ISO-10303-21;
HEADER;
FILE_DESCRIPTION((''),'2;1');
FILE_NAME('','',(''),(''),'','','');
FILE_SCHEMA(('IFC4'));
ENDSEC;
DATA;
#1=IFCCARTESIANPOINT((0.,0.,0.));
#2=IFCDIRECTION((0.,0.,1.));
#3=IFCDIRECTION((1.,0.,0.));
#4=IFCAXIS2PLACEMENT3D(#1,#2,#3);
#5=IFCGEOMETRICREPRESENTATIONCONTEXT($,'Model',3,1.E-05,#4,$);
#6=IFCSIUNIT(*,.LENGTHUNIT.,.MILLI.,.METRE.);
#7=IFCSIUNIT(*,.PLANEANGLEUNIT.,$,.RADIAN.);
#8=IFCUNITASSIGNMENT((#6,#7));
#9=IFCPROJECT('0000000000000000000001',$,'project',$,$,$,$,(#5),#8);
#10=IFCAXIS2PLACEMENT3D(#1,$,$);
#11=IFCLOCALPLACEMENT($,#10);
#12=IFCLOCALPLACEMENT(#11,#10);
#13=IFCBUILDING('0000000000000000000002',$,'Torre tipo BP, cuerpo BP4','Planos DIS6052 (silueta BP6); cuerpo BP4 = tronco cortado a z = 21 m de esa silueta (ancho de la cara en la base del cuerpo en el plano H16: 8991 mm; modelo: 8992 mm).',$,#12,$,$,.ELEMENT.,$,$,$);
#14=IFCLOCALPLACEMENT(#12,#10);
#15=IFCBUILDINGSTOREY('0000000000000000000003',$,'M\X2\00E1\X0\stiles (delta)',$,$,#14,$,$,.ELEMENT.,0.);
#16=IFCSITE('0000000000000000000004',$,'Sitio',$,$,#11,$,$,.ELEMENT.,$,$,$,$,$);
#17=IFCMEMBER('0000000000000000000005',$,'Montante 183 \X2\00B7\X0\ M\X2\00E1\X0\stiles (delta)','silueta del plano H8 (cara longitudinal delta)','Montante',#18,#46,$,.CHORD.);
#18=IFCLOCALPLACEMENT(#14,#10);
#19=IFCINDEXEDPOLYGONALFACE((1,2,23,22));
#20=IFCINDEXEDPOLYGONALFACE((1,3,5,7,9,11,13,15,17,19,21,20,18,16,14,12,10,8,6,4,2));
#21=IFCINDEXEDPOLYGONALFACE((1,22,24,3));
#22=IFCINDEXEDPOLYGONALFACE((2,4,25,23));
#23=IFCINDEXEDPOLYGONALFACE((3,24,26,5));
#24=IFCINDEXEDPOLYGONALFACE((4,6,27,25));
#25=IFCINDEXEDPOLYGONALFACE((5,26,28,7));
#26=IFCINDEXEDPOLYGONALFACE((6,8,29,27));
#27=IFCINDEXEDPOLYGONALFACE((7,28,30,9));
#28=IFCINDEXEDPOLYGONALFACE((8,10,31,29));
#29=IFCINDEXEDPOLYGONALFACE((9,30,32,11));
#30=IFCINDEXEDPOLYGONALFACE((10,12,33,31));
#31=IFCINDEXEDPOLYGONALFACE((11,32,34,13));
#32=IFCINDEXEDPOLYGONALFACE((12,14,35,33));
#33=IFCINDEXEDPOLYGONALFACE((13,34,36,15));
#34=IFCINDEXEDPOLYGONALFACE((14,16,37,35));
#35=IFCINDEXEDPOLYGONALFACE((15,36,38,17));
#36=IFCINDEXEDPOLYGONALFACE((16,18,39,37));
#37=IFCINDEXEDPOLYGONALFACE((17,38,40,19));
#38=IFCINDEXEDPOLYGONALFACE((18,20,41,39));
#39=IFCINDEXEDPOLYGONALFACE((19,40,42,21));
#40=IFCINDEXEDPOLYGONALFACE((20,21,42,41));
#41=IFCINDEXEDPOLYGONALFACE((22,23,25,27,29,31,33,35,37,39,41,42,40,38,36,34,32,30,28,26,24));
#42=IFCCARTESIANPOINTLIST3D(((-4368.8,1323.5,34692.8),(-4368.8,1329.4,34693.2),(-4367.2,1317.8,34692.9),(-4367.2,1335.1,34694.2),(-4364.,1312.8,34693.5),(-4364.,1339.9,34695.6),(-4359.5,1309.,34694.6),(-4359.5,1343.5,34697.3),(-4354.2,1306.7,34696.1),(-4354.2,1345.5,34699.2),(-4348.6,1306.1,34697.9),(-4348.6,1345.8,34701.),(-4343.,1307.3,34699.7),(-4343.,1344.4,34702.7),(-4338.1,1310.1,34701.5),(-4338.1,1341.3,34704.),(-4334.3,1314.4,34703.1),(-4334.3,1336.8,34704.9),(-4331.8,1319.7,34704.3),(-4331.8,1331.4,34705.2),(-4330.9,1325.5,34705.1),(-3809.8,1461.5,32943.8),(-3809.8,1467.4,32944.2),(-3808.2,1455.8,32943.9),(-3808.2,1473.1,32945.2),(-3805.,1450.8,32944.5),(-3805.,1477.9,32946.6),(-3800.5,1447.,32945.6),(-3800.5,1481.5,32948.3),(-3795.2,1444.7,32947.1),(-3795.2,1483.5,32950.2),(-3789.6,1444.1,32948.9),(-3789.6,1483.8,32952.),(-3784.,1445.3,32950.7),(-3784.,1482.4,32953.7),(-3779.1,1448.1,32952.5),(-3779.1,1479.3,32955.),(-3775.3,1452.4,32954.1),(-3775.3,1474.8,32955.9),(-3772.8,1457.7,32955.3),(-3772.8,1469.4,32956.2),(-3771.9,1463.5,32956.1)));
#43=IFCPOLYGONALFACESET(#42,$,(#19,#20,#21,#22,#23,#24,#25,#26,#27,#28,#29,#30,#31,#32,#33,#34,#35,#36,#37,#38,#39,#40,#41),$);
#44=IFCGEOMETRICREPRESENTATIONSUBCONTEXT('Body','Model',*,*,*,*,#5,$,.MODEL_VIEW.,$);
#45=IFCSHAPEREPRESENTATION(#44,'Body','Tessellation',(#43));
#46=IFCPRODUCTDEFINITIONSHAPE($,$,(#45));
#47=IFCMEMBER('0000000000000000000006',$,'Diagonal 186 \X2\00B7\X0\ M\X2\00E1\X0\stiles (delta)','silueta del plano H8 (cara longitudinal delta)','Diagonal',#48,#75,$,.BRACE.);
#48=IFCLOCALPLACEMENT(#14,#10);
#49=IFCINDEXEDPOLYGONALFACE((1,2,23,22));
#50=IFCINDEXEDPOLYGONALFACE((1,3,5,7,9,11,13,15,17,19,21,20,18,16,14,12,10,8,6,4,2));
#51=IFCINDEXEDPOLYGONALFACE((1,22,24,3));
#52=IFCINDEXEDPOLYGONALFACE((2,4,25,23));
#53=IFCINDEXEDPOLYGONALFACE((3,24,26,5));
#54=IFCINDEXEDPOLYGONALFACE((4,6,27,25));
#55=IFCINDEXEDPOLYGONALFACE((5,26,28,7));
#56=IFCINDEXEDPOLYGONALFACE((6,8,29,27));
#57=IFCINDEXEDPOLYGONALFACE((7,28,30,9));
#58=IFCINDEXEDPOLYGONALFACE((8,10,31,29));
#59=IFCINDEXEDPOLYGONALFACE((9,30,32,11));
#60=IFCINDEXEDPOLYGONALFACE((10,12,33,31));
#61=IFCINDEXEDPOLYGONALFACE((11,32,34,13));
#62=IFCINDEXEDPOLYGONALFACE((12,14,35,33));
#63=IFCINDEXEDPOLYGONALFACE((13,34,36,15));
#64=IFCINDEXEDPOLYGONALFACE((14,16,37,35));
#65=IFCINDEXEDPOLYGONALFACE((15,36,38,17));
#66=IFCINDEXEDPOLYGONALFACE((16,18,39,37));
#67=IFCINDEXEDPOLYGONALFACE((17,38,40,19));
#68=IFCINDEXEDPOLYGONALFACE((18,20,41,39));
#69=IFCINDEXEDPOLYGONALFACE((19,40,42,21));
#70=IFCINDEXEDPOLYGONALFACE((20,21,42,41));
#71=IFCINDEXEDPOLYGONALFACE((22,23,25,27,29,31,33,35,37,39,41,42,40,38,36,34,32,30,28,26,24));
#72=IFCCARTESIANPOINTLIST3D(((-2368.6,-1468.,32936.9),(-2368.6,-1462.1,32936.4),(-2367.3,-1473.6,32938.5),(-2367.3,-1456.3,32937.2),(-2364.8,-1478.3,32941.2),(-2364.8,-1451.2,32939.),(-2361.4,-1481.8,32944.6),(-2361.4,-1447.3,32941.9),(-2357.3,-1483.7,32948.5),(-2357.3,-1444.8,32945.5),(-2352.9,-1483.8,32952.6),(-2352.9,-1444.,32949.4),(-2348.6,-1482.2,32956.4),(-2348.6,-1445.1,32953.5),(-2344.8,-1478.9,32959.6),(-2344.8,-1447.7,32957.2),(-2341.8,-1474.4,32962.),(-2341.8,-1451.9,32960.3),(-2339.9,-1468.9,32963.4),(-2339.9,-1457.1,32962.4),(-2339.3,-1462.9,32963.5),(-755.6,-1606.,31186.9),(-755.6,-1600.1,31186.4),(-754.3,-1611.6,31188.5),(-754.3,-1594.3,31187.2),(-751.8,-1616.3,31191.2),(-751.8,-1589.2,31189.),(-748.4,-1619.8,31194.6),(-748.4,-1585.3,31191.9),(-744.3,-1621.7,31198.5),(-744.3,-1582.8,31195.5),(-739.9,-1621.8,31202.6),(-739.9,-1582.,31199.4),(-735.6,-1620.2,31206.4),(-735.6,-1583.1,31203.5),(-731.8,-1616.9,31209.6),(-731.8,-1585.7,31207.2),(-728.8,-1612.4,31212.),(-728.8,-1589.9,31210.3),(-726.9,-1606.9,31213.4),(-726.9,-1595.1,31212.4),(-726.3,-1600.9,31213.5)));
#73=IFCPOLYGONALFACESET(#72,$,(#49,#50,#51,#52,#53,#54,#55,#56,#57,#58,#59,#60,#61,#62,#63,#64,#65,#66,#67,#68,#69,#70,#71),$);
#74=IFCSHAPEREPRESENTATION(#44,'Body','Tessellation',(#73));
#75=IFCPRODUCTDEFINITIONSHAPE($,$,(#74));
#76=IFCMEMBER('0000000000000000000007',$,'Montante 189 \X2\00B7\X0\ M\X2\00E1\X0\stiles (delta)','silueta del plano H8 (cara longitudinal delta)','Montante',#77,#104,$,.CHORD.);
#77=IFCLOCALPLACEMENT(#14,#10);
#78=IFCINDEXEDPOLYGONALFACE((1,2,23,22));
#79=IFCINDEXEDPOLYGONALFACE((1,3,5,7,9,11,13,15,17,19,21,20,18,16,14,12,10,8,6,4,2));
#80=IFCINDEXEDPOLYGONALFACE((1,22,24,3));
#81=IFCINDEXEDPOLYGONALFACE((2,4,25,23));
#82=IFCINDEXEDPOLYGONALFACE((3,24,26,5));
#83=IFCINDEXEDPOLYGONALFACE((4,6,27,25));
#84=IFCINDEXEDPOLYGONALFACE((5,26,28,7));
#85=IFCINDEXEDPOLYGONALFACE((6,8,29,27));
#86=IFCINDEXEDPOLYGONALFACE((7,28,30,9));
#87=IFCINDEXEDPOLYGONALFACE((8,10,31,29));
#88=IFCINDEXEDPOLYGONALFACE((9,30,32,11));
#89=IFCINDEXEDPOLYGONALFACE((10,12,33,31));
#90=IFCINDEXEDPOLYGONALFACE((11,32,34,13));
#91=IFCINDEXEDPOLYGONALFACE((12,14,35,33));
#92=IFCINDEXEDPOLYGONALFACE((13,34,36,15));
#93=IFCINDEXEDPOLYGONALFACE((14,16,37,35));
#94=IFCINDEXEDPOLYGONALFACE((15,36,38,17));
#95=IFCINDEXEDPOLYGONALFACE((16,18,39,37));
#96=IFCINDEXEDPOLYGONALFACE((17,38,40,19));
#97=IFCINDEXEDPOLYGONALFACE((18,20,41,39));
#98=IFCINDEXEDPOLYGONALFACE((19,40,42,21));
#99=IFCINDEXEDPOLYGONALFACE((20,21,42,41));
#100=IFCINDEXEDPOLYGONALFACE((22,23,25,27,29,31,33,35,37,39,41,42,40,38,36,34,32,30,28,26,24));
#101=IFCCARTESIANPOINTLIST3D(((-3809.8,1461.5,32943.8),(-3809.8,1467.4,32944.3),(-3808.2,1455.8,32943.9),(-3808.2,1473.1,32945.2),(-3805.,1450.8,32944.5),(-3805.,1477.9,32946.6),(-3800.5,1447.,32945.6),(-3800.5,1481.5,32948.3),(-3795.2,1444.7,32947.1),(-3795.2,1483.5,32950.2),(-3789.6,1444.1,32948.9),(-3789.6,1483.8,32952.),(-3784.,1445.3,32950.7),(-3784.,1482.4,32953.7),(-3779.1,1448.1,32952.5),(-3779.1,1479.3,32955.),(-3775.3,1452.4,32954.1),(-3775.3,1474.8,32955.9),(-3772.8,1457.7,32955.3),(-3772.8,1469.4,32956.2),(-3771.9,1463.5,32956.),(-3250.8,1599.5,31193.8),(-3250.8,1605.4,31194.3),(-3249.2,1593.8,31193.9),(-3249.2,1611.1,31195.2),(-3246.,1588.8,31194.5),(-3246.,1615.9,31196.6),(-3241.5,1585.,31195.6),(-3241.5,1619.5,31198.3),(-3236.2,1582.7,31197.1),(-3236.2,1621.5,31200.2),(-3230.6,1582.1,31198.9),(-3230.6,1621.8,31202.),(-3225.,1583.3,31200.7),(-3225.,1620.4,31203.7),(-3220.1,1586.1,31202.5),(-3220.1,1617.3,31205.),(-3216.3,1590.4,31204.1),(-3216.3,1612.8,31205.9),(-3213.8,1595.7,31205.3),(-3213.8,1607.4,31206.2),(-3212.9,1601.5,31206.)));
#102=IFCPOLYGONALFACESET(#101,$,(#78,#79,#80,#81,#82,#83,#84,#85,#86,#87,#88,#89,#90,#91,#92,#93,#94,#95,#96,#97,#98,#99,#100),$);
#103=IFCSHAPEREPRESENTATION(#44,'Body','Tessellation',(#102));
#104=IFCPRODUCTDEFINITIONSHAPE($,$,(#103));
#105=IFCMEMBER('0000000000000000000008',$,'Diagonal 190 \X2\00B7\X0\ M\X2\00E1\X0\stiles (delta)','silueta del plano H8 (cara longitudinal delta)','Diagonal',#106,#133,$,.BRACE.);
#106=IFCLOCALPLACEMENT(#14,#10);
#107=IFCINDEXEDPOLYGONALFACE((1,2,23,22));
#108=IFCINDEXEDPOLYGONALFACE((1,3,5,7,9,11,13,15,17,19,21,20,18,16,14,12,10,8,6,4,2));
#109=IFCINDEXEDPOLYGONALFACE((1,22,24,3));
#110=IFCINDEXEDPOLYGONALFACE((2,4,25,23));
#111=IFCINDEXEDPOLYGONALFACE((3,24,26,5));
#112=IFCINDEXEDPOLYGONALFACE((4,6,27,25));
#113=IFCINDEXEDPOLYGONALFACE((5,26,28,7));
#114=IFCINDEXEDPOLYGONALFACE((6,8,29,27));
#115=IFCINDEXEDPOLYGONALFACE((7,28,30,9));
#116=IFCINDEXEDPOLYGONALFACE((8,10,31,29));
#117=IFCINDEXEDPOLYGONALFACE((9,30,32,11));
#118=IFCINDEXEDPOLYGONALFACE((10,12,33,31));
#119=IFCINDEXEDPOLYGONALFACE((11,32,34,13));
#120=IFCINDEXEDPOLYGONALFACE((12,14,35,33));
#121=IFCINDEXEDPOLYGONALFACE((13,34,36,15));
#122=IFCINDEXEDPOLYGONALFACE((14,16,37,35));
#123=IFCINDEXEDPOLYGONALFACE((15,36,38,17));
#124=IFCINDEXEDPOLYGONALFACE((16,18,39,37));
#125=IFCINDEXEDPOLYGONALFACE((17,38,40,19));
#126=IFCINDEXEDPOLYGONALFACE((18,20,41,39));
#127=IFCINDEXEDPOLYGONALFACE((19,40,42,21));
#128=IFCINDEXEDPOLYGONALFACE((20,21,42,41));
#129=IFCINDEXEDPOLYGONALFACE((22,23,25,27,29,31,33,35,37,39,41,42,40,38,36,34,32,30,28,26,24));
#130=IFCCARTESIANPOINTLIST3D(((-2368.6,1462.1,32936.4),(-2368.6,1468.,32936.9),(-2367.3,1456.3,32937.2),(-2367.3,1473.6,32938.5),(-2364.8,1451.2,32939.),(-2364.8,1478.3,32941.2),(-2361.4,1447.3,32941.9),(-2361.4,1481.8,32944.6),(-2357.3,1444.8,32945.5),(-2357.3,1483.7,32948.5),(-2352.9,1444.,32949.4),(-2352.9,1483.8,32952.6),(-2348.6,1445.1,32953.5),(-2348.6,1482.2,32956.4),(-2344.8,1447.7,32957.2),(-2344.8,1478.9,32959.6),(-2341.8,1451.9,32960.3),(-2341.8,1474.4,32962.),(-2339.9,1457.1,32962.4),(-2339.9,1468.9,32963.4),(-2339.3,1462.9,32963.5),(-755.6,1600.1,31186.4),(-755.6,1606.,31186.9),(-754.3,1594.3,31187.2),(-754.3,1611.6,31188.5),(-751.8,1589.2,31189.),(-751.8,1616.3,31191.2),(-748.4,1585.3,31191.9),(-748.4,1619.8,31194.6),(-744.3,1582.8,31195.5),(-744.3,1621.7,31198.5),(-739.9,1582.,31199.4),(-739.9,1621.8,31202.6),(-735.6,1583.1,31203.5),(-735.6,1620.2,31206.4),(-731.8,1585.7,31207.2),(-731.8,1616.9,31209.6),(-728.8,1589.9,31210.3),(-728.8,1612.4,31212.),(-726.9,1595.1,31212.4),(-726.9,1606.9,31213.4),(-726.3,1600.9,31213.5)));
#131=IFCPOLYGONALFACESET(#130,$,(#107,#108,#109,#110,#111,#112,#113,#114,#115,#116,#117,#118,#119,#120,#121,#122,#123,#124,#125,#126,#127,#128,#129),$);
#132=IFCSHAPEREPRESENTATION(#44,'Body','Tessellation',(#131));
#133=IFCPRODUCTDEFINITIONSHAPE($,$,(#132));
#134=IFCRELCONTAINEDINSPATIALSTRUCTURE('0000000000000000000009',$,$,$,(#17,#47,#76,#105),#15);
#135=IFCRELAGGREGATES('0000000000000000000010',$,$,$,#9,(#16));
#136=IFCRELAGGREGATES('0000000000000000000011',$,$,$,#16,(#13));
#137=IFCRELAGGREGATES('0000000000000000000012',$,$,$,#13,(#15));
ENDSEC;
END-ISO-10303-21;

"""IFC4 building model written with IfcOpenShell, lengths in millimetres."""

from ifc_helpers import new_model, si_unit, frame, origin, origin_with_axes, place, context, subcontext, project, spatial, circle, extrude, element, save


model = new_model("IFC4")

# Units and contexts
model_context = context("Model", 3, precision=1e-05, world=origin_with_axes())
body_context = subcontext(model_context, "Body", "Model", "MODEL_VIEW")
ifc_project = project(units=[si_unit("LENGTHUNIT", "METRE", prefix="MILLI"), si_unit("PLANEANGLEUNIT", "RADIAN")], contexts=[model_context])

# Site, building, storey
site_placement = place(None, origin())
site = spatial("IfcSite", under=ifc_project, at=site_placement, Name="Sitio", CompositionType="ELEMENT")
building_placement = place(site_placement, origin())
building = spatial("IfcBuilding", under=site, at=building_placement, Name="Torre tipo BP, cuerpo BP4", Description="Planos DIS6052 (silueta BP6); cuerpo BP4 = tronco cortado a z = 21 m de esa silueta (ancho de la cara en la base del cuerpo en el plano H16: 8991 mm; modelo: 8992 mm).", CompositionType="ELEMENT")
storey_placement = place(building_placement, origin())
storey = spatial("IfcBuildingStorey", under=building, at=storey_placement, Name="Mástiles (delta)", CompositionType="ELEMENT", Elevation=0.0)

# Members
for number, where, z_axis, x_axis, name in (
    (1, (-4350.0, 1326.0, 34699.0), (0.303584, 0.074945, -0.949853), (0.952805, -0.023879, 0.302643), "Montante 183 · Mástiles (delta)"),
):
    element("IfcMember", number, at=place(storey_placement, frame(where, z_axis=z_axis, x_axis=x_axis)), inside=storey, Name=name, Description="silueta del plano H8 (cara longitudinal delta)", ObjectType="Montante", PredefinedType="CHORD", context=body_context, shape_type="SweptSolid", body=[
        extrude(circle(Radius=20.0), None, (0.0, 0.0, 1.0), 1841.3),
    ])
member_1_placement = place(storey_placement, frame((-2354.0, -1464.0, 32950.0), z_axis=(0.676602, -0.057887, -0.73407), x_axis=(0.736348, 0.05319, 0.674509)))
element("IfcMember", 2, at=member_1_placement, inside=storey, Name="Diagonal 186 · Mástiles (delta)", Description="silueta del plano H8 (cara longitudinal delta)", ObjectType="Diagonal", PredefinedType="BRACE", context=body_context, shape_type="SweptSolid", body=[
    extrude(circle(Radius=20.0), None, (0.0, 0.0, 1.0), 2384.0),
])
member_2_placement = place(storey_placement, frame((-3791.0, 1464.0, 32950.0), z_axis=(0.303427, 0.074907, -0.949906), x_axis=(0.952855, -0.023853, 0.302488)))
element("IfcMember", 3, at=member_2_placement, inside=storey, Name="Montante 189 · Mástiles (delta)", Description="silueta del plano H8 (cara longitudinal delta)", ObjectType="Montante", PredefinedType="CHORD", context=body_context, shape_type="SweptSolid", body=[
    extrude(circle(Radius=20.0), None, (0.0, 0.0, 1.0), 1842.3),
])
member_3_placement = place(storey_placement, frame((-2354.0, 1464.0, 32950.0), z_axis=(0.676602, 0.057887, -0.73407), x_axis=(0.736348, -0.05319, 0.674509)))
element("IfcMember", 4, at=member_3_placement, inside=storey, Name="Diagonal 190 · Mástiles (delta)", Description="silueta del plano H8 (cara longitudinal delta)", ObjectType="Diagonal", PredefinedType="BRACE", context=body_context, shape_type="SweptSolid", body=[
    extrude(circle(Radius=20.0), None, (0.0, 0.0, 1.0), 2384.0),
])

save(model, "model.ifc")
